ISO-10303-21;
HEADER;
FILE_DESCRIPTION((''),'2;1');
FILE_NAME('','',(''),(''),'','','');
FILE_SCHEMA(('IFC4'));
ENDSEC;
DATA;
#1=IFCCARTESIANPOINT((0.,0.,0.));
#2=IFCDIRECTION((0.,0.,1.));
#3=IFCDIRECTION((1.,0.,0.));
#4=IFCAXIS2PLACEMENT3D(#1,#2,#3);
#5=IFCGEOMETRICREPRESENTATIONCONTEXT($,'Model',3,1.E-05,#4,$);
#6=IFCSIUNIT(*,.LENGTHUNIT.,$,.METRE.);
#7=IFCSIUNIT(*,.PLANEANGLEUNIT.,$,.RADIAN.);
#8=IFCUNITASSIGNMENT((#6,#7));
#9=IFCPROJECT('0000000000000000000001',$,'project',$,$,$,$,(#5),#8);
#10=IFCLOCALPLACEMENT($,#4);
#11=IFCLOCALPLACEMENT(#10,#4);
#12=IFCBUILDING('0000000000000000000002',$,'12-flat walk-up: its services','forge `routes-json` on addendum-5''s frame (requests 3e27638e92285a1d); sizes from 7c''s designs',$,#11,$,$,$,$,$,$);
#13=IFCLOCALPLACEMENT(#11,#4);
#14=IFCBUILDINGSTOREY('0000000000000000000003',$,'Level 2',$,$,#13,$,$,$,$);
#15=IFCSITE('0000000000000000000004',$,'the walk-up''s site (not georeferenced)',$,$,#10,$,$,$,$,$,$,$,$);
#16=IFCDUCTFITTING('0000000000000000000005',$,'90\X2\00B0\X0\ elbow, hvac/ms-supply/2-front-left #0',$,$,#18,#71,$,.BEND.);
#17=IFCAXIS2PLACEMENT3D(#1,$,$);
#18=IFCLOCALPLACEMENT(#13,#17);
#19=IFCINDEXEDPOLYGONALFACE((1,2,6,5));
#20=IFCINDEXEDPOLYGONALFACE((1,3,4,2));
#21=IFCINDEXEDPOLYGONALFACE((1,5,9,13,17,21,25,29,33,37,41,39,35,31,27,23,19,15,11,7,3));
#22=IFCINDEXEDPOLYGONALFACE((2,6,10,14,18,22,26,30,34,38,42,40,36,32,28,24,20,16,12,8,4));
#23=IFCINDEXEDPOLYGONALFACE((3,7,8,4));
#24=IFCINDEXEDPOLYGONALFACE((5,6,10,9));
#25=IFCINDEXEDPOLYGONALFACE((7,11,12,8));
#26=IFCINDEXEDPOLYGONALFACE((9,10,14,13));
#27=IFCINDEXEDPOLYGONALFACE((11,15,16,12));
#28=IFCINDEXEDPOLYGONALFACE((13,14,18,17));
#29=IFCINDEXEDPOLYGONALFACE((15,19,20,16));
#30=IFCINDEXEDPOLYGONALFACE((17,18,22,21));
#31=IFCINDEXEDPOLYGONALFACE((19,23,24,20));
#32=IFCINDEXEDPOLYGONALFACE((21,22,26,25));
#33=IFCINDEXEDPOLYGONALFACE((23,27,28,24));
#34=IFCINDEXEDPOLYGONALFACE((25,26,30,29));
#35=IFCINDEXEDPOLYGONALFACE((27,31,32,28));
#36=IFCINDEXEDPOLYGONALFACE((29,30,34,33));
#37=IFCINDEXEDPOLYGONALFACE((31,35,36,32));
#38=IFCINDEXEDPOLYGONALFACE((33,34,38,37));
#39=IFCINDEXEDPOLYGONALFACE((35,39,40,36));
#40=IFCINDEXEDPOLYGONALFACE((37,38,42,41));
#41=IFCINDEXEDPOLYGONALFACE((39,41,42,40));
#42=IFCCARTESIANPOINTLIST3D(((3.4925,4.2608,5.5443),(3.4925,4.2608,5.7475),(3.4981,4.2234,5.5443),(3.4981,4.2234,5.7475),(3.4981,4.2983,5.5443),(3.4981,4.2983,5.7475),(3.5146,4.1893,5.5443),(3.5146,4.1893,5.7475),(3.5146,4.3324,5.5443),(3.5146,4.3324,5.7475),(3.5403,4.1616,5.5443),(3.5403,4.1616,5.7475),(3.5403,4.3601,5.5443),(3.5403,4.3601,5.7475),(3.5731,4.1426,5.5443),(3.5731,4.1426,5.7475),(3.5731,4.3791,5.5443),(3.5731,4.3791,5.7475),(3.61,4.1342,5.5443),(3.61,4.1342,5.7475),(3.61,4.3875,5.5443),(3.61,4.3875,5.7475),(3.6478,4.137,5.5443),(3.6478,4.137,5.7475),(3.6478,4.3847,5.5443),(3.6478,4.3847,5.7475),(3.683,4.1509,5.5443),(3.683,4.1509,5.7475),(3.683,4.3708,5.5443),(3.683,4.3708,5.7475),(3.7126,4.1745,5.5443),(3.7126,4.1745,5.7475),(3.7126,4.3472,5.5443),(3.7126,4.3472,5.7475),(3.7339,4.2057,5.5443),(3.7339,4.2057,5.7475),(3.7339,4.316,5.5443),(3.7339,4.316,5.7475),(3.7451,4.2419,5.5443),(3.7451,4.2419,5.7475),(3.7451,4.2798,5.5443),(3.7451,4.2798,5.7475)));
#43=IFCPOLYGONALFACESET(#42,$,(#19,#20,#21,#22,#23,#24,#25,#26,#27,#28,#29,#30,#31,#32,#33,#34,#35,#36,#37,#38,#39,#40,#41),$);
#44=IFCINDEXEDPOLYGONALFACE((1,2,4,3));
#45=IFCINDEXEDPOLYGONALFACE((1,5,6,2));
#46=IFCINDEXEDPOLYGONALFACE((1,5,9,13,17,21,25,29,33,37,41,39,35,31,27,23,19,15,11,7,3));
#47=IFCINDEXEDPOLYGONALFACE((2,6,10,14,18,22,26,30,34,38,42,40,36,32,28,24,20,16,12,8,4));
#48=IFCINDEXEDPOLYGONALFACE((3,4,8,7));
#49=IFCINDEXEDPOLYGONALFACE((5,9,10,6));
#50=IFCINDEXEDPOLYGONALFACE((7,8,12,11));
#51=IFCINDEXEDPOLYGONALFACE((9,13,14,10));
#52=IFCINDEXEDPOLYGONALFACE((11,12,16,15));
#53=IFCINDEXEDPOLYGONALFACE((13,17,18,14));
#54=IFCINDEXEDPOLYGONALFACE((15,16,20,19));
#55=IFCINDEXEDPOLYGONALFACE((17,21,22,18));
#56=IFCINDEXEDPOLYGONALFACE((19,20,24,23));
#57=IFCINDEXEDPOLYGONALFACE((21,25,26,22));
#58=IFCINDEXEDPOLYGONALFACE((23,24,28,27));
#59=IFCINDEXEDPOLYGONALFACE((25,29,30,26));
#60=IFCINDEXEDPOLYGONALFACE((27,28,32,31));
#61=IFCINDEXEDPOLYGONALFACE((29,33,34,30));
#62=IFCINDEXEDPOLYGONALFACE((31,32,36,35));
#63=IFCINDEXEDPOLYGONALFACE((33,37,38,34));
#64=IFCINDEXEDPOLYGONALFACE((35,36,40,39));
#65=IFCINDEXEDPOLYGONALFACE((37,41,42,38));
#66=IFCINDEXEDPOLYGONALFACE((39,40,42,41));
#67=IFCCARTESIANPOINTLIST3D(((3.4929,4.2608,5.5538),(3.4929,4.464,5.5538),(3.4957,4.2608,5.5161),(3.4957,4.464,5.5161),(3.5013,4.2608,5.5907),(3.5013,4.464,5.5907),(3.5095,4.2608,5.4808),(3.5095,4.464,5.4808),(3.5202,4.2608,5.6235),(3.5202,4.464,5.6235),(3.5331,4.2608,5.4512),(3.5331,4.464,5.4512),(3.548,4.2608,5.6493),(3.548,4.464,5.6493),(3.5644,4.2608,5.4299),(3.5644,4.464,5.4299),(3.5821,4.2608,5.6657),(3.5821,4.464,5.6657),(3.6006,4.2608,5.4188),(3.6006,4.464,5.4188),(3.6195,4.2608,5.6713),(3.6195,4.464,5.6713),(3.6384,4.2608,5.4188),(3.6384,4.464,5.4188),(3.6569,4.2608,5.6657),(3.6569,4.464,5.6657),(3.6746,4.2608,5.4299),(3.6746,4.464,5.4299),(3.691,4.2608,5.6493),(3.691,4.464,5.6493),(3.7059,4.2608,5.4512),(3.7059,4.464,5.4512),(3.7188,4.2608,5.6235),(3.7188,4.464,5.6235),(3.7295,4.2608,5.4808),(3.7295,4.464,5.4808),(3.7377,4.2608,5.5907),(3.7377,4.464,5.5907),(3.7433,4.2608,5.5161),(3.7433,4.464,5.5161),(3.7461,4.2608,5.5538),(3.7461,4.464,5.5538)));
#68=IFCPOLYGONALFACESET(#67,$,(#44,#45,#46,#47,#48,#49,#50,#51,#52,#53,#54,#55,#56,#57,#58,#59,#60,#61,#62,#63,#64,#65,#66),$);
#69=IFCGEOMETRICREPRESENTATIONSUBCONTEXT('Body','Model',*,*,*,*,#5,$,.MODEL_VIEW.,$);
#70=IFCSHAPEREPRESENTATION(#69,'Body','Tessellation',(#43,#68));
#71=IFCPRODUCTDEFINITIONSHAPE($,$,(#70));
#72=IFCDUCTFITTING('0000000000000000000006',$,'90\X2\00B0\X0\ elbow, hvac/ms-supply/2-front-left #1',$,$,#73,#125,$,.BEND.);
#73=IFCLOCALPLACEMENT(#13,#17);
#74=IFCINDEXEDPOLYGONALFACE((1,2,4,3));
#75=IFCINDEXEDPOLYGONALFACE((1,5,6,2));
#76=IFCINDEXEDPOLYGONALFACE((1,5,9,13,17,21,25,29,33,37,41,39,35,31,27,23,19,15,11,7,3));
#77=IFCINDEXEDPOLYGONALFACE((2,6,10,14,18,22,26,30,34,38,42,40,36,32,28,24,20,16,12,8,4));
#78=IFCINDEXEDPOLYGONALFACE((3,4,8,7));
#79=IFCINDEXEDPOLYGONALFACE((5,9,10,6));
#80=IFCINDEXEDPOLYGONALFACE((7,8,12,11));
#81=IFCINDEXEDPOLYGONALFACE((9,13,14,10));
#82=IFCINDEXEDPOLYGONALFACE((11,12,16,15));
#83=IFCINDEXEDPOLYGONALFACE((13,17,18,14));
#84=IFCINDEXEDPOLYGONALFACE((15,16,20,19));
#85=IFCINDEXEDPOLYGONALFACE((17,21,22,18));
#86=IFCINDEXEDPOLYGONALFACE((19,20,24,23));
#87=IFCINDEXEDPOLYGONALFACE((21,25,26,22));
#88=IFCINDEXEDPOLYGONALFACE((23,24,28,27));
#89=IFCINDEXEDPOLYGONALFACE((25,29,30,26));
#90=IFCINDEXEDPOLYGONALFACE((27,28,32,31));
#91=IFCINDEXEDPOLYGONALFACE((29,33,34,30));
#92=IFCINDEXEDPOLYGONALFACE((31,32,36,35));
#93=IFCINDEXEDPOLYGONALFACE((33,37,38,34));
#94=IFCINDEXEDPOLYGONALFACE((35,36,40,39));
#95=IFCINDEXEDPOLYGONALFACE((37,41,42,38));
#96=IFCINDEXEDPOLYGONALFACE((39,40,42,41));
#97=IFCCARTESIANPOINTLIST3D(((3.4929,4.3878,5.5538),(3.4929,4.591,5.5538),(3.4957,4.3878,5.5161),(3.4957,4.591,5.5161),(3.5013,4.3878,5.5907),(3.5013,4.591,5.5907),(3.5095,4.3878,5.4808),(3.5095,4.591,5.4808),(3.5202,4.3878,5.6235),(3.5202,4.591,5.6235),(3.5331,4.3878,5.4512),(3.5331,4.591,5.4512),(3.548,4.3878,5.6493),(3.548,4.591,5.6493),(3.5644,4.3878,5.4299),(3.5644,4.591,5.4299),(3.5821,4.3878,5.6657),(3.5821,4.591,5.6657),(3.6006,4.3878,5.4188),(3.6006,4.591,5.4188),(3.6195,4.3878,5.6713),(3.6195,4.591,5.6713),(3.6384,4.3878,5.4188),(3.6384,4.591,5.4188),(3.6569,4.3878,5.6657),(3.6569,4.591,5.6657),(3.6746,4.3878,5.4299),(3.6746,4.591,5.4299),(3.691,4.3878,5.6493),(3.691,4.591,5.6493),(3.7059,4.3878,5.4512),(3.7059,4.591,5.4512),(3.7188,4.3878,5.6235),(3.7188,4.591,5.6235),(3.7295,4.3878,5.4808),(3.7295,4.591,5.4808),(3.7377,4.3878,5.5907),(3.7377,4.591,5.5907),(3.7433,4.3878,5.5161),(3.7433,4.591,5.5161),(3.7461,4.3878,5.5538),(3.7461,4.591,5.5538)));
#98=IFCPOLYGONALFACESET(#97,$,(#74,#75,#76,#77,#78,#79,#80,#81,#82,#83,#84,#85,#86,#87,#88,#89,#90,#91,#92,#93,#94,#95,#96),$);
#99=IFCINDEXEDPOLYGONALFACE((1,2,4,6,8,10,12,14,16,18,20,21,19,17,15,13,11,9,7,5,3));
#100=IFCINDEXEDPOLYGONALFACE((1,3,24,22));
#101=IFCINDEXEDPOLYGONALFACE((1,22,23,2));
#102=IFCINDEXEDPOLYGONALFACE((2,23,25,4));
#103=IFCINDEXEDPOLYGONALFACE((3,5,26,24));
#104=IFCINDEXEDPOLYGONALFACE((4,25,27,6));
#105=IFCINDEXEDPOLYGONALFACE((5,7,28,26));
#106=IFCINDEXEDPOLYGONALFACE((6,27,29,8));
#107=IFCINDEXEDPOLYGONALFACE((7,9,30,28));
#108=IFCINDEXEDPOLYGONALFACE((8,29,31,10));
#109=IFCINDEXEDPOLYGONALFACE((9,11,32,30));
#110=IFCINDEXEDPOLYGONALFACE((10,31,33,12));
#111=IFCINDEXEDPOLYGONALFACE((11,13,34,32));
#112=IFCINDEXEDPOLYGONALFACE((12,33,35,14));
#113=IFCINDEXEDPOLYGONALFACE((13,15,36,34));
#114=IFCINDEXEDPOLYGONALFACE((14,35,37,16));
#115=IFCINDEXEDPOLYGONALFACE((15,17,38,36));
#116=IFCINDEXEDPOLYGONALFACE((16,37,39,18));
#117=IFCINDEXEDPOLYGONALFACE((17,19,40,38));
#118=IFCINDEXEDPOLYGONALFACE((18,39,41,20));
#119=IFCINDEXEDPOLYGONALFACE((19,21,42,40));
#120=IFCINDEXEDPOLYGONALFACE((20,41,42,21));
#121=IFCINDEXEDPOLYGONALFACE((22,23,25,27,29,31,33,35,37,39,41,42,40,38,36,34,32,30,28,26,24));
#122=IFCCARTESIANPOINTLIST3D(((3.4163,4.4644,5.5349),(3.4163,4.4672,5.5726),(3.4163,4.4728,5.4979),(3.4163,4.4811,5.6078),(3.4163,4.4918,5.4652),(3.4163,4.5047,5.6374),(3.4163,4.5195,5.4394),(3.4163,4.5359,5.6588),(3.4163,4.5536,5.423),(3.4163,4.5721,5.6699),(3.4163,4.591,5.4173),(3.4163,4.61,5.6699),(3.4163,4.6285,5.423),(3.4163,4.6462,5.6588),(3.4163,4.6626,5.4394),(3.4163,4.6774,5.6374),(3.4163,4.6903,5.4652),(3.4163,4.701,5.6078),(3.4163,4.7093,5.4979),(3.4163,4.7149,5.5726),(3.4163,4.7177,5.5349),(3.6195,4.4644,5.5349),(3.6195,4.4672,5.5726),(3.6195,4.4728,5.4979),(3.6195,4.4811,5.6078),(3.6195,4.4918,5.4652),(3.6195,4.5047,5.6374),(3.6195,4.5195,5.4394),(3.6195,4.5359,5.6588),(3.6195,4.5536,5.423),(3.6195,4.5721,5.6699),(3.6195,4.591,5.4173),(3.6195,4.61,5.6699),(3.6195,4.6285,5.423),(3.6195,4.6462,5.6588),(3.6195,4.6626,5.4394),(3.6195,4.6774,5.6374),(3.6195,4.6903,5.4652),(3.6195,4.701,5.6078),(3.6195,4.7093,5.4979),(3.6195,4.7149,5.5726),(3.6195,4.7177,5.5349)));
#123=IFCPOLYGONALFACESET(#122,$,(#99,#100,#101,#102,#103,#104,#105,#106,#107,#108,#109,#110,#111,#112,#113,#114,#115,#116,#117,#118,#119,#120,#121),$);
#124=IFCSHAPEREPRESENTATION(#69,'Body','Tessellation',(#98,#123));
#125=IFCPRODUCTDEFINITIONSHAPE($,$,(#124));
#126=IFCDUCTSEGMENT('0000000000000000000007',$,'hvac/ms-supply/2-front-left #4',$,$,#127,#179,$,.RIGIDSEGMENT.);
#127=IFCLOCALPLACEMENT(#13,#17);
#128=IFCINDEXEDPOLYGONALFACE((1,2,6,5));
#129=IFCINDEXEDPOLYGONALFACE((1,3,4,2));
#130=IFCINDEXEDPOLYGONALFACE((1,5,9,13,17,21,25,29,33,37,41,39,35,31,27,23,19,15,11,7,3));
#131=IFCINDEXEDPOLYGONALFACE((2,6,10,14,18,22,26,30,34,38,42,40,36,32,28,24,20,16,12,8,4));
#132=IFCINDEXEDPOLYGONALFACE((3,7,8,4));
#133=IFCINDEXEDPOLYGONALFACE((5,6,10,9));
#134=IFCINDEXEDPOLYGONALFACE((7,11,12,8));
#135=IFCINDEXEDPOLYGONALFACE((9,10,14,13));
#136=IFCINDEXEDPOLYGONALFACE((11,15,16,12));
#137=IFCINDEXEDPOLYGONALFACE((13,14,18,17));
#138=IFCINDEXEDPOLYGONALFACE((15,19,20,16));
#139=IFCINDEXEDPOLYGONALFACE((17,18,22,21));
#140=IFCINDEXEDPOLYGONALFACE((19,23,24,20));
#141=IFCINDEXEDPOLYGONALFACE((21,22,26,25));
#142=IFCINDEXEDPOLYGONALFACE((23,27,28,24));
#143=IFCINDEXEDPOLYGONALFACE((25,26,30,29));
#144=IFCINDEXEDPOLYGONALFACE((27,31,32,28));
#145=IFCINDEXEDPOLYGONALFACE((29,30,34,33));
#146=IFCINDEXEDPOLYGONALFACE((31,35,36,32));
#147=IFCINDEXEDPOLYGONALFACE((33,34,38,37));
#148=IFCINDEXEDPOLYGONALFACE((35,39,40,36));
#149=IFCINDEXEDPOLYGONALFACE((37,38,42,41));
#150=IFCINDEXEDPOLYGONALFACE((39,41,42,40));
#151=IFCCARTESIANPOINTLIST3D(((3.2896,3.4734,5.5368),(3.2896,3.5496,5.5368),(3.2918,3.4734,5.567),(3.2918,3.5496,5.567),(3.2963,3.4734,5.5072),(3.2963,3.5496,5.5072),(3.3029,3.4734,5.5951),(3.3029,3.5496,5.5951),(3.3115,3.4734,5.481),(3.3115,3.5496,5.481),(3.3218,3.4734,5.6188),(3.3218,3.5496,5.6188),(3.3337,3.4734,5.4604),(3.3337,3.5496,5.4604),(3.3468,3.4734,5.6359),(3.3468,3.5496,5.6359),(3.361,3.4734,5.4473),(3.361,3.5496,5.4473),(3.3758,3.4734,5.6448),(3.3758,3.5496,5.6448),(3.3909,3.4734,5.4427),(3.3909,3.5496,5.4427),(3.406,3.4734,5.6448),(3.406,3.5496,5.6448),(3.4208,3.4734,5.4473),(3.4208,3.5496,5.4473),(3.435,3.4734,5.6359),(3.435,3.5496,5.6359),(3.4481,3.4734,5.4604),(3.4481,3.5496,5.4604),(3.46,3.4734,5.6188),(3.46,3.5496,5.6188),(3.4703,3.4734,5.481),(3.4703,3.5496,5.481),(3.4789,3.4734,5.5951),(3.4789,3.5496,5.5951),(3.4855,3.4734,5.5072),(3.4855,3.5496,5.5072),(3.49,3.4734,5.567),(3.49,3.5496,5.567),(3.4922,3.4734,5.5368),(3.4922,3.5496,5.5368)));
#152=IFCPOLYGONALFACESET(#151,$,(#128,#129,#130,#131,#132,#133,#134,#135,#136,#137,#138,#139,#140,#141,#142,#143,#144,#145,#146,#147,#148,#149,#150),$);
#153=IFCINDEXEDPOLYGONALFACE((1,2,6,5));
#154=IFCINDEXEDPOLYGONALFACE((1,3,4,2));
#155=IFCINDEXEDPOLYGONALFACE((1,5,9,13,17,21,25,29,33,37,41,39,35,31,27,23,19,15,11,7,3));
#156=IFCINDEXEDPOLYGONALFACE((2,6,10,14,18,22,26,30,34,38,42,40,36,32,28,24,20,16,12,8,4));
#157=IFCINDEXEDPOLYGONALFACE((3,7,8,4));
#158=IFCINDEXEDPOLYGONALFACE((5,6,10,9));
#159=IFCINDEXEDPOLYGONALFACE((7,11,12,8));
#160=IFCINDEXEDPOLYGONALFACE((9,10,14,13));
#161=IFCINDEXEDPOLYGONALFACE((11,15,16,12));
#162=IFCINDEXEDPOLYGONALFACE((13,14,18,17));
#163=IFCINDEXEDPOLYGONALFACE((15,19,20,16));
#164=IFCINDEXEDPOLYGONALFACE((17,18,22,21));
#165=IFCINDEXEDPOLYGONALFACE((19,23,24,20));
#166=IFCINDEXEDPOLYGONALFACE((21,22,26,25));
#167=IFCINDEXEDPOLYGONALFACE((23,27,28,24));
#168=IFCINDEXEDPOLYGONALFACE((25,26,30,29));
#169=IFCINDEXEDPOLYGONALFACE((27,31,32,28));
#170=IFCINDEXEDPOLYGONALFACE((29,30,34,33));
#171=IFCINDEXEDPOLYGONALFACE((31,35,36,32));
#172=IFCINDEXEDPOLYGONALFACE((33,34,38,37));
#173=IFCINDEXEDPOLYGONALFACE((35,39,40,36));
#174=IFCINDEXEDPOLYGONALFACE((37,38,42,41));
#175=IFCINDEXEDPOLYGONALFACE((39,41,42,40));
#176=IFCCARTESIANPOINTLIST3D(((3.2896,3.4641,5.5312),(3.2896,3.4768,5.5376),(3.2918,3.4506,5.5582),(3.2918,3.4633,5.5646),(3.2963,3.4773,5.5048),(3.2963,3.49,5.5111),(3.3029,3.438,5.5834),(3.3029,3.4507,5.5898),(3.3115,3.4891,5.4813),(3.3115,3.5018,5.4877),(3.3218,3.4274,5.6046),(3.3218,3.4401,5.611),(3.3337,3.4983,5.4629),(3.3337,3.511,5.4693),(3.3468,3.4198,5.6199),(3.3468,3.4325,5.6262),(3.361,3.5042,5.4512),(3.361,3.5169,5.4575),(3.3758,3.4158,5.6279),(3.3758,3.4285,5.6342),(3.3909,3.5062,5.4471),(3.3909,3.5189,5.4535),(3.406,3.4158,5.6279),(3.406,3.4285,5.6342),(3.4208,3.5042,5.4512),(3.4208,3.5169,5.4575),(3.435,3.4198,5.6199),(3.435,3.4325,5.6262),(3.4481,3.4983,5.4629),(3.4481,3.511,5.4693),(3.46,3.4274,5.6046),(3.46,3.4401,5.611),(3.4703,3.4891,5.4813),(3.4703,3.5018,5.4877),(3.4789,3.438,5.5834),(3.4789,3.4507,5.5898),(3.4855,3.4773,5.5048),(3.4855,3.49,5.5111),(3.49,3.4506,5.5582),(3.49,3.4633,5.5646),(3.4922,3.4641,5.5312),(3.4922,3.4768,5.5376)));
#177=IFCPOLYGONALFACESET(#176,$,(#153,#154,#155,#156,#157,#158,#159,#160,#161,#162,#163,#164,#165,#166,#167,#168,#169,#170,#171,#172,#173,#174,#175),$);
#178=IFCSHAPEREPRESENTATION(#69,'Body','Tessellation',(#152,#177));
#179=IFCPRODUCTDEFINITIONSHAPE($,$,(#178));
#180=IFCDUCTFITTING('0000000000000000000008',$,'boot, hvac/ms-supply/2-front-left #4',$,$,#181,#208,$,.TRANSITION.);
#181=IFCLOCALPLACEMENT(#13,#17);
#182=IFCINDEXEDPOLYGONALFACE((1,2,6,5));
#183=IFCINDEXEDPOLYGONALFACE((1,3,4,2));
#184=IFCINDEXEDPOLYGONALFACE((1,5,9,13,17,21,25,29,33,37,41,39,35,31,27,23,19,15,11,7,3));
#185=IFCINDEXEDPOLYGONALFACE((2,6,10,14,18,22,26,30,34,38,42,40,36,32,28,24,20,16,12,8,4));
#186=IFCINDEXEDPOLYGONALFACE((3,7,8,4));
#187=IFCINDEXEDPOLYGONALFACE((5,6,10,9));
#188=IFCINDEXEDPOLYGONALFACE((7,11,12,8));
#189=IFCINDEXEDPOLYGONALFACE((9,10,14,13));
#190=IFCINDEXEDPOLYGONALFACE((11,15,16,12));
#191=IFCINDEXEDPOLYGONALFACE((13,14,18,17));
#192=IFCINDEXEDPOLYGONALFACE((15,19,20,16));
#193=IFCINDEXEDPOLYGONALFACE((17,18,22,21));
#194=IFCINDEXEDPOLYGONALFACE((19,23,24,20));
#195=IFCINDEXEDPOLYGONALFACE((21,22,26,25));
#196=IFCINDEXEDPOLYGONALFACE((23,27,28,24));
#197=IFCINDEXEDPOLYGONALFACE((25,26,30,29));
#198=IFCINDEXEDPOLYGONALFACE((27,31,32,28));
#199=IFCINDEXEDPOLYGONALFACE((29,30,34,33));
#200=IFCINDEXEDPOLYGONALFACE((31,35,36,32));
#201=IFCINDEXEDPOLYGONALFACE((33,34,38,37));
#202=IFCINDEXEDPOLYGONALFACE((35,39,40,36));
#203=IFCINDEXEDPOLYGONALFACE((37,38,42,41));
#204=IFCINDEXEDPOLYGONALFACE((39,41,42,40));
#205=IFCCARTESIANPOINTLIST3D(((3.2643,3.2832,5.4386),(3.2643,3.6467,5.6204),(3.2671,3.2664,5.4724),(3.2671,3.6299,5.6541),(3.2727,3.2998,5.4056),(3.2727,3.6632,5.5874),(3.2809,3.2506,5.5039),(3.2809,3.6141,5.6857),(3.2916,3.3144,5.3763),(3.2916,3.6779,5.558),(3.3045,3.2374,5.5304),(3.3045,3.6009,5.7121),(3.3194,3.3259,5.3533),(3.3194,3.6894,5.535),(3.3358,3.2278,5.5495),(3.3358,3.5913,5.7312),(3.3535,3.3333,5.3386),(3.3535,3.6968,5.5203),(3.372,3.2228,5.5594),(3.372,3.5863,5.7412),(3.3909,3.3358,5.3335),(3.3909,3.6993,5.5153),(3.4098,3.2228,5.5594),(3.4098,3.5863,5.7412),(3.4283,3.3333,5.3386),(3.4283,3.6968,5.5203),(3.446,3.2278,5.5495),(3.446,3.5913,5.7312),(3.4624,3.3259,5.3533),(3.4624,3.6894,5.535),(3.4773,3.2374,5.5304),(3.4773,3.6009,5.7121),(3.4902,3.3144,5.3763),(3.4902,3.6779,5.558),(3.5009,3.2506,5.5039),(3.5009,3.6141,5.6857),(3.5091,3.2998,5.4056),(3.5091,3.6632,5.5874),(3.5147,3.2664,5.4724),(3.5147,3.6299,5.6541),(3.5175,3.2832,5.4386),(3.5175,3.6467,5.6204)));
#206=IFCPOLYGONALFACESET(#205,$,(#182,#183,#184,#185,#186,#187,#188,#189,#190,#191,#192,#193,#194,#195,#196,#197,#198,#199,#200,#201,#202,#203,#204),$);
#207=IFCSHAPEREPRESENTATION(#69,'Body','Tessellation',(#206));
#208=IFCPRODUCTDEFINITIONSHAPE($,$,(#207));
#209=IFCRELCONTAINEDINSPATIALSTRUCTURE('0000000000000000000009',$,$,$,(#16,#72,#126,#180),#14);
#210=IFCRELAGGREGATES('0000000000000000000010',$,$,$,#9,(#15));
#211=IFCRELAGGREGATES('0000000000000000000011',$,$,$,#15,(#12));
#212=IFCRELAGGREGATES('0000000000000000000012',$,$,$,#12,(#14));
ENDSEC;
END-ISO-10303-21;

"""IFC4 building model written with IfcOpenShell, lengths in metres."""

from ifc_helpers import new_model, entity, si_unit, frame, origin_with_axes, place, context, subcontext, project, spatial, element, save


model = new_model("IFC4")

# Units and contexts
model_context = context("Model", 3, precision=1e-05, world=origin_with_axes())
body_context = subcontext(model_context, "Body", "Model", "MODEL_VIEW")
ifc_project = project(units=[si_unit("LENGTHUNIT", "METRE"), si_unit("PLANEANGLEUNIT", "RADIAN")], contexts=[model_context])

# Site, building, storey
site_placement = place(None, origin_with_axes())
site = spatial("IfcSite", under=ifc_project, at=site_placement, Name="the walk-up's site (not georeferenced)")
building_placement = place(site_placement, origin_with_axes())
building = spatial("IfcBuilding", under=site, at=building_placement, Name="12-flat walk-up: its services", Description="forge `routes-json` on addendum-5's frame (requests 3e27638e92285a1d); sizes from 7c's designs")
storey_placement = place(building_placement, origin_with_axes())
storey = spatial("IfcBuildingStorey", under=building, at=storey_placement, Name="Level 2")

# Duct fittings
duct_fitting_1_placement = place(storey_placement, frame((3.6195, 4.2608, 5.7475), z_axis=(0.0, 0.0, 1.0), x_axis=(1.0, 0.0, 0.0)))
element("IfcDuctFitting", 1, at=duct_fitting_1_placement, inside=storey, Name="90° elbow, hvac/ms-supply/2-front-left #0", PredefinedType="BEND", context=body_context, shape_type="AdvancedSweptSolid", body=[
    entity("IfcSweptDiskSolid", entity("IfcPolyline", [entity("IfcCartesianPoint", [0.0, 0.0, 0.0]), entity("IfcCartesianPoint", [0.0, 0.0, -0.2032])]), 0.127),
    entity("IfcSweptDiskSolid", entity("IfcPolyline", [entity("IfcCartesianPoint", [0.0, 0.0, -0.2032]), entity("IfcCartesianPoint", [0.0, 0.2032, -0.2032])]), 0.127),
])
duct_fitting_2_placement = place(storey_placement, frame((3.6195, 4.3879, 5.5443), z_axis=(0.0, 0.0, 1.0), x_axis=(1.0, 0.0, 0.0)))
element("IfcDuctFitting", 2, at=duct_fitting_2_placement, inside=storey, Name="90° elbow, hvac/ms-supply/2-front-left #1", PredefinedType="BEND", context=body_context, shape_type="AdvancedSweptSolid", body=[
    entity("IfcSweptDiskSolid", entity("IfcPolyline", [entity("IfcCartesianPoint", [0.0, 0.0, 0.0]), entity("IfcCartesianPoint", [0.0, 0.2032, 0.0])]), 0.127),
    entity("IfcSweptDiskSolid", entity("IfcPolyline", [entity("IfcCartesianPoint", [0.0, 0.2032, 0.0]), entity("IfcCartesianPoint", [-0.2032, 0.2032, 0.0])]), 0.127),
])

# Duct segment
duct_segment_1_placement = place(storey_placement, frame((3.3909, 3.5496, 5.5443), z_axis=(0.0, 0.0, 1.0), x_axis=(1.0, 0.0, 0.0)))
element("IfcDuctSegment", 3, at=duct_segment_1_placement, inside=storey, Name="hvac/ms-supply/2-front-left #4", PredefinedType="RIGIDSEGMENT", context=body_context, shape_type="AdvancedSweptSolid", body=[
    entity("IfcSweptDiskSolid", entity("IfcPolyline", [entity("IfcCartesianPoint", [0.0, 0.0, 0.0]), entity("IfcCartesianPoint", [0.0, -0.0762, 0.0])]), 0.1016),
    entity("IfcSweptDiskSolid", entity("IfcPolyline", [entity("IfcCartesianPoint", [0.0, -0.0762, 0.0]), entity("IfcCartesianPoint", [0.0, -0.0889, -0.0063])]), 0.1016),
])

# Duct fitting
duct_fitting_3_placement = place(storey_placement, frame((3.3909, 3.6425, 5.6289), z_axis=(0.0, 0.0, 1.0), x_axis=(1.0, 0.0, 0.0)))
element("IfcDuctFitting", 4, at=duct_fitting_3_placement, inside=storey, Name="boot, hvac/ms-supply/2-front-left #4", PredefinedType="TRANSITION", context=body_context, shape_type="AdvancedSweptSolid", body=[
    entity("IfcSweptDiskSolid", entity("IfcPolyline", [entity("IfcCartesianPoint", [0.0, 0.0, 0.0]), entity("IfcCartesianPoint", [0.0, -0.3635, -0.1817])]), 0.127),
])

save(model, "model.ifc")
